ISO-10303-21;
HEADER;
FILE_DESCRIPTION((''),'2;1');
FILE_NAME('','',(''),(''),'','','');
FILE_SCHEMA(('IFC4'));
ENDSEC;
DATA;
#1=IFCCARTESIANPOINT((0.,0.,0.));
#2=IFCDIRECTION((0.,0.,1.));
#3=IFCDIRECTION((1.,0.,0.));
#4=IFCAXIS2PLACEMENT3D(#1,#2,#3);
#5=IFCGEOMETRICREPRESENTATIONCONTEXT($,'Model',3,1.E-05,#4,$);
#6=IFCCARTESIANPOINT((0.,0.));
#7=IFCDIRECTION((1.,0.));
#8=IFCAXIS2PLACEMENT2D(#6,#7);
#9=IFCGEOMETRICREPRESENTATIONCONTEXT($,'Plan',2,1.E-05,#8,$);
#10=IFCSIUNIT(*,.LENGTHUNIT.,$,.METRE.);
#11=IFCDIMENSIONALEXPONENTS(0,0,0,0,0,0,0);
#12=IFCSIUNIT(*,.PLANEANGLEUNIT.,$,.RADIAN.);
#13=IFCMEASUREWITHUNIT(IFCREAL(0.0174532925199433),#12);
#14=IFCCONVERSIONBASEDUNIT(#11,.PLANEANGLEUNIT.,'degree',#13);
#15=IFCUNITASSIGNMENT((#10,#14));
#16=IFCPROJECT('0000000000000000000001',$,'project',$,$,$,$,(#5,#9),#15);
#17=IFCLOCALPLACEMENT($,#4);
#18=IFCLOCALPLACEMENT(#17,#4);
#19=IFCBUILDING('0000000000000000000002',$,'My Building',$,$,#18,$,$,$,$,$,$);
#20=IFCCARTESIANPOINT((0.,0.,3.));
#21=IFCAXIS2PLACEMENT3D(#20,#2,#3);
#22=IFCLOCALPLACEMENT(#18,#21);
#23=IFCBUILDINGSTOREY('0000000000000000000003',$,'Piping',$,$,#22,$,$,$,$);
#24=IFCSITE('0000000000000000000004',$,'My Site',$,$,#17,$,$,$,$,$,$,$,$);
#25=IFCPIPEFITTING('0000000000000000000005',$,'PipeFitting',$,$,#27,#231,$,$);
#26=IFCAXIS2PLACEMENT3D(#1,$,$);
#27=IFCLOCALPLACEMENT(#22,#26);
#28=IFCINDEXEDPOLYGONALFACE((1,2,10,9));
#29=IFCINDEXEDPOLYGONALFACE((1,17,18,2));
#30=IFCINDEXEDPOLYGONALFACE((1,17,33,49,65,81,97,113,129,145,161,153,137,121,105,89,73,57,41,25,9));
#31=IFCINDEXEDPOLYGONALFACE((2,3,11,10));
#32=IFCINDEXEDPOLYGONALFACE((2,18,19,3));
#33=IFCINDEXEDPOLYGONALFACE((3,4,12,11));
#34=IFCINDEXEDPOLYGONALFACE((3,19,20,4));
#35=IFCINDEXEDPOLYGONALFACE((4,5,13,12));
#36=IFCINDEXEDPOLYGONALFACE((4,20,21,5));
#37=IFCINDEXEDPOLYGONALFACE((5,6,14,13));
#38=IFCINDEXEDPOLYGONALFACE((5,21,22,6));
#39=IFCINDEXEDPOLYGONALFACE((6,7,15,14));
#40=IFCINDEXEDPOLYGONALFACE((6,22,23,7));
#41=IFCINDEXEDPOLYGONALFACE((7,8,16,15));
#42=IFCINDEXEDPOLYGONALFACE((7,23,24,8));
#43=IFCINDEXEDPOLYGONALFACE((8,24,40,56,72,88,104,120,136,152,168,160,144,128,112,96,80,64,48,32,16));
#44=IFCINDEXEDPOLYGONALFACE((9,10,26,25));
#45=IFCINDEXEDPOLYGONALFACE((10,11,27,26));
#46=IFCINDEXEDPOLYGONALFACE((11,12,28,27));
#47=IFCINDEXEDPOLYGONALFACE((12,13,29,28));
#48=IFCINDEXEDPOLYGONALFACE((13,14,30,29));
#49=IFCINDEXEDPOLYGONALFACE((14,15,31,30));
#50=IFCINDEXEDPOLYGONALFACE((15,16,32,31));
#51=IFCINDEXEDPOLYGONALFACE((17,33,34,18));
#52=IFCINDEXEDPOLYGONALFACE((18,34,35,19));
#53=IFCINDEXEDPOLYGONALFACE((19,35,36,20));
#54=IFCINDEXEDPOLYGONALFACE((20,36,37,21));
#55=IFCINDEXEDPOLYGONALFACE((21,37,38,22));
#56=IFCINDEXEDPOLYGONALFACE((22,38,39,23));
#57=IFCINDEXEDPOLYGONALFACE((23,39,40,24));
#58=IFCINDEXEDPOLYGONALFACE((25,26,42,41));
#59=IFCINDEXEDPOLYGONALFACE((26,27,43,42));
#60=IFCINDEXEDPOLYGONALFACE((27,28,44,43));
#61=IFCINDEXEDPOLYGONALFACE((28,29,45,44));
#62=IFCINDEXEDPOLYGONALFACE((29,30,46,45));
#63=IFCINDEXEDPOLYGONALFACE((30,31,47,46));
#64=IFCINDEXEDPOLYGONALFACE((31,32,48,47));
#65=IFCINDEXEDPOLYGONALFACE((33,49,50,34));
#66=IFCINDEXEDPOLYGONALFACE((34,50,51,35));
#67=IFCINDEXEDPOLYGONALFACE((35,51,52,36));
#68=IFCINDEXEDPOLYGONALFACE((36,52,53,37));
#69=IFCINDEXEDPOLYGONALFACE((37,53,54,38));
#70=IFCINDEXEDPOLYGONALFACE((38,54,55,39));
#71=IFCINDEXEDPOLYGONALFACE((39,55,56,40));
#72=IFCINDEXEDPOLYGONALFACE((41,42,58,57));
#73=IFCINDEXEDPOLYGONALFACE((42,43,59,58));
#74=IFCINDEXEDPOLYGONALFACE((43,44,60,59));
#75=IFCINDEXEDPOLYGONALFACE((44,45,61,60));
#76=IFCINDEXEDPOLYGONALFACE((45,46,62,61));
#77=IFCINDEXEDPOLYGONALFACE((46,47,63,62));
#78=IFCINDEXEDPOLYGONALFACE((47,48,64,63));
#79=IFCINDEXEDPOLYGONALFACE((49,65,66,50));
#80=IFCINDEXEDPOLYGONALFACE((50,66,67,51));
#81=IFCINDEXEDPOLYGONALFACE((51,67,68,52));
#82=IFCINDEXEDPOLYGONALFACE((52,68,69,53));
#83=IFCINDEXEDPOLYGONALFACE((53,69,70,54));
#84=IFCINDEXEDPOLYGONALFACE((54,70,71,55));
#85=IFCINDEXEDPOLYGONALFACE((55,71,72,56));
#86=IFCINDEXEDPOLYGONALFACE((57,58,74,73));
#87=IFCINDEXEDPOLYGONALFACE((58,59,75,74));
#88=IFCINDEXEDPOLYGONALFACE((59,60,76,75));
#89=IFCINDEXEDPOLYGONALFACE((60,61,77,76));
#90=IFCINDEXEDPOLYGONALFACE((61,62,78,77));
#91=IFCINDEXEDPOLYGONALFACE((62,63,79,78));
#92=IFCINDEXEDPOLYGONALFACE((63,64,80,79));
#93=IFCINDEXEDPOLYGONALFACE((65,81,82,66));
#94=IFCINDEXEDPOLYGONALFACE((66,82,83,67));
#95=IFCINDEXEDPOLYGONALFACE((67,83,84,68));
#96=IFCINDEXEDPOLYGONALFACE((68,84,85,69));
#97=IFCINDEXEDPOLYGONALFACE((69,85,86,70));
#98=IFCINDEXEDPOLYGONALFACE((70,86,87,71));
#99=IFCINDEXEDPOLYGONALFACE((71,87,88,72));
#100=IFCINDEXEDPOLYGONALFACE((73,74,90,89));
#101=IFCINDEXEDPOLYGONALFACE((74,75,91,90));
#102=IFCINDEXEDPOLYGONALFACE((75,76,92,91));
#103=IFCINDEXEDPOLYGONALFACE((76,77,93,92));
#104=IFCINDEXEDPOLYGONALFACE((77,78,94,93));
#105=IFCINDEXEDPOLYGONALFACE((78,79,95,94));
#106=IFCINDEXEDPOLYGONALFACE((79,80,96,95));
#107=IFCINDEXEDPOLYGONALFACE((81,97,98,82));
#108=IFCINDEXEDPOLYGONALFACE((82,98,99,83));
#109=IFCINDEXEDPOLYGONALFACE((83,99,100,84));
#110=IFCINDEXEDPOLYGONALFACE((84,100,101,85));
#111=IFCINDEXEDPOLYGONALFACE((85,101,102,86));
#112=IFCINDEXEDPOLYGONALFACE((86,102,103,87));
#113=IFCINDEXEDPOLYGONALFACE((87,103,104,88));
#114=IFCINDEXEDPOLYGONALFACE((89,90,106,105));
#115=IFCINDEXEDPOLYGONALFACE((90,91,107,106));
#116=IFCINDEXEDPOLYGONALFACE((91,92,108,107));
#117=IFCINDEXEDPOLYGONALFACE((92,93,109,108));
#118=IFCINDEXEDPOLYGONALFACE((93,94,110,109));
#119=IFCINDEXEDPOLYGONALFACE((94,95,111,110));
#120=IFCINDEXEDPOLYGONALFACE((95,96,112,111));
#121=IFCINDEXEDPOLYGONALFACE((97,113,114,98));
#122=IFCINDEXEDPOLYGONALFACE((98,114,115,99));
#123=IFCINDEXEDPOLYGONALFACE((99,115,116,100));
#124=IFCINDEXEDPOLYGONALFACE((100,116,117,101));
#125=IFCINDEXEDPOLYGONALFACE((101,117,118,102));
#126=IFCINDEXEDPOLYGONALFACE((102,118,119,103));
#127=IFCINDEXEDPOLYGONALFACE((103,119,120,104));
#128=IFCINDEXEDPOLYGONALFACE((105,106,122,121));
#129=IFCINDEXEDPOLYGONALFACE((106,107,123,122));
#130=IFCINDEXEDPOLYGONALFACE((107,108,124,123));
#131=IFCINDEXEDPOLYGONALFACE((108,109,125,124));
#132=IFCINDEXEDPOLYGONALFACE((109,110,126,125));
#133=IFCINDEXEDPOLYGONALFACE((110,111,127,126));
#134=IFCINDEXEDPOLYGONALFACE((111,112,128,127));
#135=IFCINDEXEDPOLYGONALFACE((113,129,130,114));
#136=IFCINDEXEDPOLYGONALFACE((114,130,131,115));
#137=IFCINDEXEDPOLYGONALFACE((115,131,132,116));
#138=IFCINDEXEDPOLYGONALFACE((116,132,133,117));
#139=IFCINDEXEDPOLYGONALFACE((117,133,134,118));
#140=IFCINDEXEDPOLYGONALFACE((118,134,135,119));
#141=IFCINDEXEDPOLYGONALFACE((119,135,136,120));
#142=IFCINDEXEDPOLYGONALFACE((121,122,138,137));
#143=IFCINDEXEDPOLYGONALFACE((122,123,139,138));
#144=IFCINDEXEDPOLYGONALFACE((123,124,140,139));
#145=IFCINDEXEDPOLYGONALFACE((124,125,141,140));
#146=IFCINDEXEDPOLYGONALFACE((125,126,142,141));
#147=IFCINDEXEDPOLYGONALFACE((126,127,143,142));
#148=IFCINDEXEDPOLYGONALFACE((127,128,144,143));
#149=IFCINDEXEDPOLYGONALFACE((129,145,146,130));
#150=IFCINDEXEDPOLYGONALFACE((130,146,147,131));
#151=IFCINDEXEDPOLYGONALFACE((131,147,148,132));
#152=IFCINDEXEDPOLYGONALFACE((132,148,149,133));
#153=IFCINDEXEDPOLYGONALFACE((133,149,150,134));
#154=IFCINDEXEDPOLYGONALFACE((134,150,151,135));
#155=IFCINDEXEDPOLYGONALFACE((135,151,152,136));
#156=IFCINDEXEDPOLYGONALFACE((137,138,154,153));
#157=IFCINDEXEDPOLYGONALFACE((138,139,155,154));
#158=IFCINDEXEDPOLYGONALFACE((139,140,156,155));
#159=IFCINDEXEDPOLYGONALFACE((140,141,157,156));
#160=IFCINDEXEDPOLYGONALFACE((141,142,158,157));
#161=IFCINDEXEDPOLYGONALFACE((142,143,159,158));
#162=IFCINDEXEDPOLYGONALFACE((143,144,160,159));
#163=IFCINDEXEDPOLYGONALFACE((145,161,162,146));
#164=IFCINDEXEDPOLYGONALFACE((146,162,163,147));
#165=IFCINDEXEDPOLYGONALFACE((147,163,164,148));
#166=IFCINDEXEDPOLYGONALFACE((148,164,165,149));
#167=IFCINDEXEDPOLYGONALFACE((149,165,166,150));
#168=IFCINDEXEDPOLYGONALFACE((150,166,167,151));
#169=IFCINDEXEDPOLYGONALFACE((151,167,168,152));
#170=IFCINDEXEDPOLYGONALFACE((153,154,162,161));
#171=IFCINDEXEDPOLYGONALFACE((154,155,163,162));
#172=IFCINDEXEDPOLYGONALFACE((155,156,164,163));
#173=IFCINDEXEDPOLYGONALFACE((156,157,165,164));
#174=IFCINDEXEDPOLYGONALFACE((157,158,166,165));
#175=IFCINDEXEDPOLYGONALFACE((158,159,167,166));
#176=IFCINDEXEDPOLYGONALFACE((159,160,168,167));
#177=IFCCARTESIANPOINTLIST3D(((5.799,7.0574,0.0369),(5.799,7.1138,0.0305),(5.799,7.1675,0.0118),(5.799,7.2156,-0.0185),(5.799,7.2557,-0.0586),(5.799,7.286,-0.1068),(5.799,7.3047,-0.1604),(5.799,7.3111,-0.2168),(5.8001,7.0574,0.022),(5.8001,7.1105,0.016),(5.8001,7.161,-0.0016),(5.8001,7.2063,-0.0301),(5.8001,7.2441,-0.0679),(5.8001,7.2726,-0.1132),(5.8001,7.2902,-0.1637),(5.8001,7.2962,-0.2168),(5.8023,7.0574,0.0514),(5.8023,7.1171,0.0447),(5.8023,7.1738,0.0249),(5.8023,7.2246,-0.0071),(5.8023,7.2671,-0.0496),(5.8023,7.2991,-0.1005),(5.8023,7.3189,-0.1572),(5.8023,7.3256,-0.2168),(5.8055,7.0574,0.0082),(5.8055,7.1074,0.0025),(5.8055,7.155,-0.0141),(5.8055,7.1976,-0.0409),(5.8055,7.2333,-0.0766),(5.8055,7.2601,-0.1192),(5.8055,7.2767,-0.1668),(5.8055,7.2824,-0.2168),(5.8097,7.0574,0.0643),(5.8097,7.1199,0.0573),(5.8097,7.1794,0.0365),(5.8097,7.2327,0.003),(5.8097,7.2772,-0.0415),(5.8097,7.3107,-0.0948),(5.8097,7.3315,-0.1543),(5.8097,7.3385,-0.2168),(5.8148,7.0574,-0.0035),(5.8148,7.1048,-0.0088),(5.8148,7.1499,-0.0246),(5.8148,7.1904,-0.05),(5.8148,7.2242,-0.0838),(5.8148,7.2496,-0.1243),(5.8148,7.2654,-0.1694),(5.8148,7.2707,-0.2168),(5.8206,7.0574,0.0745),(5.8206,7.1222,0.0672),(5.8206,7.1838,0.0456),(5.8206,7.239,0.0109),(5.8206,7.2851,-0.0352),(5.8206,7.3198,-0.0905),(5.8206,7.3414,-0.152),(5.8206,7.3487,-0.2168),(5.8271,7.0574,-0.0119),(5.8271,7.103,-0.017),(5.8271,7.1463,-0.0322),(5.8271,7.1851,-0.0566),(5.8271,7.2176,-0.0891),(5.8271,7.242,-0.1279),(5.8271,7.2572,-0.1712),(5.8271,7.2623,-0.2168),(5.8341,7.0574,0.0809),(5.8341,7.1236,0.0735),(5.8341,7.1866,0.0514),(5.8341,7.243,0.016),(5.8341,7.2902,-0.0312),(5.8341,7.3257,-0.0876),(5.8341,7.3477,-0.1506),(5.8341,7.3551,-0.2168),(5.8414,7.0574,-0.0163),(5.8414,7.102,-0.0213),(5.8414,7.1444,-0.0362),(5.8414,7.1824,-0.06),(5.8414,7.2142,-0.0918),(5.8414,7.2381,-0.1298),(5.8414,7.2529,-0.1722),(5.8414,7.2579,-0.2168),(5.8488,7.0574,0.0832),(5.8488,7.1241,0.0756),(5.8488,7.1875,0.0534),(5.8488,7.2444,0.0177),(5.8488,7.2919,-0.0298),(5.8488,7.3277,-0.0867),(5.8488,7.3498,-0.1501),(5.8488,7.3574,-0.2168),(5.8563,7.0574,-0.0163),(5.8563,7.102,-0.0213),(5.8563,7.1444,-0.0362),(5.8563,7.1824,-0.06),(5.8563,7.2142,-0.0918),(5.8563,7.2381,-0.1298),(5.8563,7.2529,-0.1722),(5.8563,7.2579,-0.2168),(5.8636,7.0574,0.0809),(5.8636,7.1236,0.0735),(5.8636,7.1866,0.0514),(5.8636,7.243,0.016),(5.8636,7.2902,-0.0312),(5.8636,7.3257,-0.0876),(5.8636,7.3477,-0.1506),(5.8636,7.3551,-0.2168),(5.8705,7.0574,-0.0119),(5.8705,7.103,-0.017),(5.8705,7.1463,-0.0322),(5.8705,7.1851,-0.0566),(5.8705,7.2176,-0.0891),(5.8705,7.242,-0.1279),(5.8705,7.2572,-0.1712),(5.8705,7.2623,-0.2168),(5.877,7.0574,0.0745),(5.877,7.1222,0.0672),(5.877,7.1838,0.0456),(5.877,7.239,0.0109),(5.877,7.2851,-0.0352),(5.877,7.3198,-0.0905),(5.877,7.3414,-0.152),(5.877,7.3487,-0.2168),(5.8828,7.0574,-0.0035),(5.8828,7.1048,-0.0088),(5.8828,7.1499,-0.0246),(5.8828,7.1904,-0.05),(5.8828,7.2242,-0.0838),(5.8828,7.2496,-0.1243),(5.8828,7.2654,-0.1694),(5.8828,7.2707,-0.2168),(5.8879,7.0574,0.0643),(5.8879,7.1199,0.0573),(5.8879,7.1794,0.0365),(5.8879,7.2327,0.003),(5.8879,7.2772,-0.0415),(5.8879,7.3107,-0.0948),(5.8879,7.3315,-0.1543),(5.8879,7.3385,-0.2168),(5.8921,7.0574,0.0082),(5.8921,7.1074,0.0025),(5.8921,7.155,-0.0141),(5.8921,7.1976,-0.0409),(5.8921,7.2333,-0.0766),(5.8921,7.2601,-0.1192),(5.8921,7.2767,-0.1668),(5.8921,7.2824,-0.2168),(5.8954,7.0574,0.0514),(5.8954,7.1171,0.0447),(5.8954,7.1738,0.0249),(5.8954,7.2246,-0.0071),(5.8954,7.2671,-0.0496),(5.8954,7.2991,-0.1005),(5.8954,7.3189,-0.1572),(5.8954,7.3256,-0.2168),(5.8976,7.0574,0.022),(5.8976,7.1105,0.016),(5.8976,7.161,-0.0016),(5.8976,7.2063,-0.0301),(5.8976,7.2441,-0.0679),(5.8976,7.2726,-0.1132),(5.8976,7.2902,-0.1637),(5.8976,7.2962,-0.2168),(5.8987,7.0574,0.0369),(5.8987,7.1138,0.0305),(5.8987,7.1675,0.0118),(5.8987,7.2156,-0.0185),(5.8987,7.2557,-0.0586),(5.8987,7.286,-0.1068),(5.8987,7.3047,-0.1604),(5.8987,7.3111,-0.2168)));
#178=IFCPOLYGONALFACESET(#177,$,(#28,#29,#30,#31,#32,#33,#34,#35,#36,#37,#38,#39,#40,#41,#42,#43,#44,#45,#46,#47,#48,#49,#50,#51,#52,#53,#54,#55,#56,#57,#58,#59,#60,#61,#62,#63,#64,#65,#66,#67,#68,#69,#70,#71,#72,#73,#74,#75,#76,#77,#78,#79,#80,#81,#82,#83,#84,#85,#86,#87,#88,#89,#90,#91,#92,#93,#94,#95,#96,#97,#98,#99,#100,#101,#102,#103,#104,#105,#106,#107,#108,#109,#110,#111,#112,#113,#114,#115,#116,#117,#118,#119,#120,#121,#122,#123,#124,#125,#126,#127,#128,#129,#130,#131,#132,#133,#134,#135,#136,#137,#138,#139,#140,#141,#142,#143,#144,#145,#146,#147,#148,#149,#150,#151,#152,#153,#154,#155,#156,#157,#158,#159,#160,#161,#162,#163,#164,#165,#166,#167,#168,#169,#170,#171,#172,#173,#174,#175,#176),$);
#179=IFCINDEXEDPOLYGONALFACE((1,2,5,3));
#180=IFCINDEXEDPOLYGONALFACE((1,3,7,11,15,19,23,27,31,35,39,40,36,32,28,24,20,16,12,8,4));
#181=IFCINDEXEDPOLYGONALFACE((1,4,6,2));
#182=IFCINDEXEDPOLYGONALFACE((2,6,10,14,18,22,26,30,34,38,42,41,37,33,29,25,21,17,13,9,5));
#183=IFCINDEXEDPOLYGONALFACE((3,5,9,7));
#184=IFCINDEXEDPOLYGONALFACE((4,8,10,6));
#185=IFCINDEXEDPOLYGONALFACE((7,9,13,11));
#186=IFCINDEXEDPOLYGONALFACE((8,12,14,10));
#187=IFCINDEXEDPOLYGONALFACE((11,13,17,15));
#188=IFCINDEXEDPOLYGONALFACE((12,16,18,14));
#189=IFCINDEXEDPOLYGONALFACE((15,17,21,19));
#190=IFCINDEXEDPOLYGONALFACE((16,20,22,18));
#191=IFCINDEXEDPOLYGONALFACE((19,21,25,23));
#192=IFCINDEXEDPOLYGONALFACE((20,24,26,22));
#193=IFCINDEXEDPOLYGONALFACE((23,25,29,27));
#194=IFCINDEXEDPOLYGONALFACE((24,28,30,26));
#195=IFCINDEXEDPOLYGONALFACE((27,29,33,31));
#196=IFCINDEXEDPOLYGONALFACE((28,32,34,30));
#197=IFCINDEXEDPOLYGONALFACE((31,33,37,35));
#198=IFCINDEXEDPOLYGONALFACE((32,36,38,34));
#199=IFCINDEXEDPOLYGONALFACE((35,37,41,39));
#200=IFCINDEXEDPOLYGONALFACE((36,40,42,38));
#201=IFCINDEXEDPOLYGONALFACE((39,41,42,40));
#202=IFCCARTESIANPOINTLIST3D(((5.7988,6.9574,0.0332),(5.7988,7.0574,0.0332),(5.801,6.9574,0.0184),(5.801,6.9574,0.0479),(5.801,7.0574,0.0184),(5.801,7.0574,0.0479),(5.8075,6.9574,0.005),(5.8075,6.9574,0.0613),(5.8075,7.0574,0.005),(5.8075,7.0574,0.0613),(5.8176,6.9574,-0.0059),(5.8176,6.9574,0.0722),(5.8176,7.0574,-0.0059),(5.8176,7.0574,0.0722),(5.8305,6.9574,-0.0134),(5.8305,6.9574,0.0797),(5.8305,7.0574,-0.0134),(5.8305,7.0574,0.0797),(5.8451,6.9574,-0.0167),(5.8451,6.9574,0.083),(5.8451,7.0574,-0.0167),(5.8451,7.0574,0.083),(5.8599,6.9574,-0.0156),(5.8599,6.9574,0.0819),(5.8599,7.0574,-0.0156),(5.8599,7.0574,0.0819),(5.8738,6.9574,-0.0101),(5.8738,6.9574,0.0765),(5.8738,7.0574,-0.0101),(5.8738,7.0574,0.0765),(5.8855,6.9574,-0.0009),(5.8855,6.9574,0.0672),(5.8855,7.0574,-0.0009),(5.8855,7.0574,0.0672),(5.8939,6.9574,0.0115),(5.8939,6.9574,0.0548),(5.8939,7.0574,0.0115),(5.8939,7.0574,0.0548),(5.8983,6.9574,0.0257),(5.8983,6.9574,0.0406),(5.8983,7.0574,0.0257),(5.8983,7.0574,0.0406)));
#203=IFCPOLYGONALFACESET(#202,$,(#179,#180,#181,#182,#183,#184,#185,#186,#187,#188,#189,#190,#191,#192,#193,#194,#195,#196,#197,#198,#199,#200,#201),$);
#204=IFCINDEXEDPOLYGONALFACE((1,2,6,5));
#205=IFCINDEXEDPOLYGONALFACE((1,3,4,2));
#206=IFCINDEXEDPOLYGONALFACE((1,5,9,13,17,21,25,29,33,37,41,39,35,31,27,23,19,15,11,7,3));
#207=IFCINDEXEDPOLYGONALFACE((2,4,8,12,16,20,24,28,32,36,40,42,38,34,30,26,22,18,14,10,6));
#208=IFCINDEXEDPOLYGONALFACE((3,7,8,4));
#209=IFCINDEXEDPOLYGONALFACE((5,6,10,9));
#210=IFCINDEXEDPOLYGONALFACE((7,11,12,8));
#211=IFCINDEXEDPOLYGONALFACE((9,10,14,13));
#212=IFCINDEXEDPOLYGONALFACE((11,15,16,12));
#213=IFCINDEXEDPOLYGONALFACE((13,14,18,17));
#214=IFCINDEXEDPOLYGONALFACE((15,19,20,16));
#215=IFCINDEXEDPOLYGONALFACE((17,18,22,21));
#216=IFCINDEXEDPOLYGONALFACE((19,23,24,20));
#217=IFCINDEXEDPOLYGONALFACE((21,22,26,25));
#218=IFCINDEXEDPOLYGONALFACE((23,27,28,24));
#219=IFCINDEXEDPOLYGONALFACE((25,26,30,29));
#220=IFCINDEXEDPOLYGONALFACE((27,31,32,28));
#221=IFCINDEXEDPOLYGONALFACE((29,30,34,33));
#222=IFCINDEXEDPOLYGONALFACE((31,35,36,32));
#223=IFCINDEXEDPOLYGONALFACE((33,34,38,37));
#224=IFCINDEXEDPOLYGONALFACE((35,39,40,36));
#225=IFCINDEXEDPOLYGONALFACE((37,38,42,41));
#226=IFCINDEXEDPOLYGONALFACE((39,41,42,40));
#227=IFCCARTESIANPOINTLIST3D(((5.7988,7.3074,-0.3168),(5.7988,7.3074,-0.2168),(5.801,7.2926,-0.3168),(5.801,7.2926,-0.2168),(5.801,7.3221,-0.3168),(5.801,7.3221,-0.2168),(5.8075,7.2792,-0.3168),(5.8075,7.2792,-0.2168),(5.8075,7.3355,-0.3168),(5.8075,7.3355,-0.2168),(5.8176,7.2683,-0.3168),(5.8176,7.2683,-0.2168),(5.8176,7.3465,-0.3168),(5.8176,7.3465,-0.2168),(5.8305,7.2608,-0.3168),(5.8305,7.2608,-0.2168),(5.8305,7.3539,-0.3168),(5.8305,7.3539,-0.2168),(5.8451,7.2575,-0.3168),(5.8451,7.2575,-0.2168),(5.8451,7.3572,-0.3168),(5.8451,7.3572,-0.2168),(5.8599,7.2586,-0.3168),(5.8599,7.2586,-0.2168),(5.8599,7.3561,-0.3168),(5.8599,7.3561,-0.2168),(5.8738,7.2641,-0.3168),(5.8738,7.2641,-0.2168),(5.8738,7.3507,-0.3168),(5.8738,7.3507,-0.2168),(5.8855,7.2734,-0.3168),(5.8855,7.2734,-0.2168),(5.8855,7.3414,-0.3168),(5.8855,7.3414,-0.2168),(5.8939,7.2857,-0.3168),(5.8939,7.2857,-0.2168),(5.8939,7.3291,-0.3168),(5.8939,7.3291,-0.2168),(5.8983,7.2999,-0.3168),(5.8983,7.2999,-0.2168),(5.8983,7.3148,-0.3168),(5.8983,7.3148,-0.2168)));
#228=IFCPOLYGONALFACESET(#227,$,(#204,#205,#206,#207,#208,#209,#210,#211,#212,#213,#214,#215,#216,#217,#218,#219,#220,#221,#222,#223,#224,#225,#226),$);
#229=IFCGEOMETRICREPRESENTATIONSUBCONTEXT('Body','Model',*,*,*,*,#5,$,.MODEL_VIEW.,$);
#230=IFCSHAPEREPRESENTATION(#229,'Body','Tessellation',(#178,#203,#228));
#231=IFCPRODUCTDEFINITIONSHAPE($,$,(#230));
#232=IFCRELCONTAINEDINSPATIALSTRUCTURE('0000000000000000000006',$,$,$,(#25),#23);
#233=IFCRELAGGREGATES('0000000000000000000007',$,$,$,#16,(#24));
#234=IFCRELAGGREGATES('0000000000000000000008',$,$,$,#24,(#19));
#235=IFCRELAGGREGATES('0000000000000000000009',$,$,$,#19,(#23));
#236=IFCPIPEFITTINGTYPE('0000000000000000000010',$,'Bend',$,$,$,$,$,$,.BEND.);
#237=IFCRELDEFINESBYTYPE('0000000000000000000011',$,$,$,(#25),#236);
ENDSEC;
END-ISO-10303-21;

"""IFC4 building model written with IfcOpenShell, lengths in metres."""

from ifc_helpers import new_model, entity, si_unit, converted_unit, frame, origin_with_axes, origin_2d_with_axis, place, context, subcontext, project, spatial, circle, extrude, source, transform, mapped, type_object, type_shapes, element, save


model = new_model("IFC4")

# Units and contexts
model_context = context("Model", 3, precision=1e-05, world=origin_with_axes())
plan_context = context("Plan", 2, precision=1e-05, world=origin_2d_with_axis())
body_context = subcontext(model_context, "Body", "Model", "MODEL_VIEW")
ifc_project = project(units=[si_unit("LENGTHUNIT", "METRE"), converted_unit("PLANEANGLEUNIT", "degree", entity("IfcReal", 0.0174532925199433), si_unit("PLANEANGLEUNIT", "RADIAN"), dimensions=[0, 0, 0, 0, 0, 0, 0])], contexts=[model_context, plan_context])

# Site, building, storey
site_placement = place(None, origin_with_axes())
site = spatial("IfcSite", under=ifc_project, at=site_placement, Name="My Site")
building_placement = place(site_placement, origin_with_axes())
building = spatial("IfcBuilding", under=site, at=building_placement, Name="My Building")
storey_placement = place(building_placement, frame((0.0, 0.0, 3.0), z_axis=(0.0, 0.0, 1.0), x_axis=(1.0, 0.0, 0.0)))
storey = spatial("IfcBuildingStorey", under=building, at=storey_placement, Name="Piping")

# Pipe fitting
pipe_fitting_type = type_object("IfcPipeFittingType", Name="Bend", PredefinedType="BEND")
shared_shape = source(origin_with_axes(), body_context, "Body", "SolidModel", [
    entity("IfcSweptDiskSolid", entity("IfcIndexedPolyCurve", entity("IfcCartesianPointList3D", [[0.0, 0.0, -0.1], [0.0, 0.0732, -0.2768], [0.0, 0.25, -0.35]]), [entity("IfcArcIndex", [1, 2, 3])]), 0.05),
    extrude(circle(Radius=0.05), origin_with_axes(), (0.0, 0.0, -1.0), 0.1),
    extrude(circle(Radius=0.05), frame((0.0, 0.25, -0.35), z_axis=(0.0, 1.0, 0.0), x_axis=(1.0, 0.0, 0.0)), (0.0, 0.0, 1.0), 0.1),
])
type_shapes(pipe_fitting_type, [shared_shape])
for number, where, z_axis, x_axis, name in (
    (1, (5.8488, 6.9574, 0.0332), (0.0, -1.0, 0.0), (-1.0, 0.0, 0.0), "PipeFitting"),
):
    element("IfcPipeFitting", number, at=place(storey_placement, frame(where, z_axis=z_axis, x_axis=x_axis)), inside=storey, type_object=pipe_fitting_type, Name=name, context=body_context, shape_type="MappedRepresentation", body=[
        mapped(shared_shape, transform((0.0, 0.0, 0.0), x_axis=(1.0, 0.0, 0.0), y_axis=(0.0, 1.0, 0.0), z_axis=(0.0, 0.0, 1.0), scale=1.0)),
    ])

save(model, "model.ifc")
